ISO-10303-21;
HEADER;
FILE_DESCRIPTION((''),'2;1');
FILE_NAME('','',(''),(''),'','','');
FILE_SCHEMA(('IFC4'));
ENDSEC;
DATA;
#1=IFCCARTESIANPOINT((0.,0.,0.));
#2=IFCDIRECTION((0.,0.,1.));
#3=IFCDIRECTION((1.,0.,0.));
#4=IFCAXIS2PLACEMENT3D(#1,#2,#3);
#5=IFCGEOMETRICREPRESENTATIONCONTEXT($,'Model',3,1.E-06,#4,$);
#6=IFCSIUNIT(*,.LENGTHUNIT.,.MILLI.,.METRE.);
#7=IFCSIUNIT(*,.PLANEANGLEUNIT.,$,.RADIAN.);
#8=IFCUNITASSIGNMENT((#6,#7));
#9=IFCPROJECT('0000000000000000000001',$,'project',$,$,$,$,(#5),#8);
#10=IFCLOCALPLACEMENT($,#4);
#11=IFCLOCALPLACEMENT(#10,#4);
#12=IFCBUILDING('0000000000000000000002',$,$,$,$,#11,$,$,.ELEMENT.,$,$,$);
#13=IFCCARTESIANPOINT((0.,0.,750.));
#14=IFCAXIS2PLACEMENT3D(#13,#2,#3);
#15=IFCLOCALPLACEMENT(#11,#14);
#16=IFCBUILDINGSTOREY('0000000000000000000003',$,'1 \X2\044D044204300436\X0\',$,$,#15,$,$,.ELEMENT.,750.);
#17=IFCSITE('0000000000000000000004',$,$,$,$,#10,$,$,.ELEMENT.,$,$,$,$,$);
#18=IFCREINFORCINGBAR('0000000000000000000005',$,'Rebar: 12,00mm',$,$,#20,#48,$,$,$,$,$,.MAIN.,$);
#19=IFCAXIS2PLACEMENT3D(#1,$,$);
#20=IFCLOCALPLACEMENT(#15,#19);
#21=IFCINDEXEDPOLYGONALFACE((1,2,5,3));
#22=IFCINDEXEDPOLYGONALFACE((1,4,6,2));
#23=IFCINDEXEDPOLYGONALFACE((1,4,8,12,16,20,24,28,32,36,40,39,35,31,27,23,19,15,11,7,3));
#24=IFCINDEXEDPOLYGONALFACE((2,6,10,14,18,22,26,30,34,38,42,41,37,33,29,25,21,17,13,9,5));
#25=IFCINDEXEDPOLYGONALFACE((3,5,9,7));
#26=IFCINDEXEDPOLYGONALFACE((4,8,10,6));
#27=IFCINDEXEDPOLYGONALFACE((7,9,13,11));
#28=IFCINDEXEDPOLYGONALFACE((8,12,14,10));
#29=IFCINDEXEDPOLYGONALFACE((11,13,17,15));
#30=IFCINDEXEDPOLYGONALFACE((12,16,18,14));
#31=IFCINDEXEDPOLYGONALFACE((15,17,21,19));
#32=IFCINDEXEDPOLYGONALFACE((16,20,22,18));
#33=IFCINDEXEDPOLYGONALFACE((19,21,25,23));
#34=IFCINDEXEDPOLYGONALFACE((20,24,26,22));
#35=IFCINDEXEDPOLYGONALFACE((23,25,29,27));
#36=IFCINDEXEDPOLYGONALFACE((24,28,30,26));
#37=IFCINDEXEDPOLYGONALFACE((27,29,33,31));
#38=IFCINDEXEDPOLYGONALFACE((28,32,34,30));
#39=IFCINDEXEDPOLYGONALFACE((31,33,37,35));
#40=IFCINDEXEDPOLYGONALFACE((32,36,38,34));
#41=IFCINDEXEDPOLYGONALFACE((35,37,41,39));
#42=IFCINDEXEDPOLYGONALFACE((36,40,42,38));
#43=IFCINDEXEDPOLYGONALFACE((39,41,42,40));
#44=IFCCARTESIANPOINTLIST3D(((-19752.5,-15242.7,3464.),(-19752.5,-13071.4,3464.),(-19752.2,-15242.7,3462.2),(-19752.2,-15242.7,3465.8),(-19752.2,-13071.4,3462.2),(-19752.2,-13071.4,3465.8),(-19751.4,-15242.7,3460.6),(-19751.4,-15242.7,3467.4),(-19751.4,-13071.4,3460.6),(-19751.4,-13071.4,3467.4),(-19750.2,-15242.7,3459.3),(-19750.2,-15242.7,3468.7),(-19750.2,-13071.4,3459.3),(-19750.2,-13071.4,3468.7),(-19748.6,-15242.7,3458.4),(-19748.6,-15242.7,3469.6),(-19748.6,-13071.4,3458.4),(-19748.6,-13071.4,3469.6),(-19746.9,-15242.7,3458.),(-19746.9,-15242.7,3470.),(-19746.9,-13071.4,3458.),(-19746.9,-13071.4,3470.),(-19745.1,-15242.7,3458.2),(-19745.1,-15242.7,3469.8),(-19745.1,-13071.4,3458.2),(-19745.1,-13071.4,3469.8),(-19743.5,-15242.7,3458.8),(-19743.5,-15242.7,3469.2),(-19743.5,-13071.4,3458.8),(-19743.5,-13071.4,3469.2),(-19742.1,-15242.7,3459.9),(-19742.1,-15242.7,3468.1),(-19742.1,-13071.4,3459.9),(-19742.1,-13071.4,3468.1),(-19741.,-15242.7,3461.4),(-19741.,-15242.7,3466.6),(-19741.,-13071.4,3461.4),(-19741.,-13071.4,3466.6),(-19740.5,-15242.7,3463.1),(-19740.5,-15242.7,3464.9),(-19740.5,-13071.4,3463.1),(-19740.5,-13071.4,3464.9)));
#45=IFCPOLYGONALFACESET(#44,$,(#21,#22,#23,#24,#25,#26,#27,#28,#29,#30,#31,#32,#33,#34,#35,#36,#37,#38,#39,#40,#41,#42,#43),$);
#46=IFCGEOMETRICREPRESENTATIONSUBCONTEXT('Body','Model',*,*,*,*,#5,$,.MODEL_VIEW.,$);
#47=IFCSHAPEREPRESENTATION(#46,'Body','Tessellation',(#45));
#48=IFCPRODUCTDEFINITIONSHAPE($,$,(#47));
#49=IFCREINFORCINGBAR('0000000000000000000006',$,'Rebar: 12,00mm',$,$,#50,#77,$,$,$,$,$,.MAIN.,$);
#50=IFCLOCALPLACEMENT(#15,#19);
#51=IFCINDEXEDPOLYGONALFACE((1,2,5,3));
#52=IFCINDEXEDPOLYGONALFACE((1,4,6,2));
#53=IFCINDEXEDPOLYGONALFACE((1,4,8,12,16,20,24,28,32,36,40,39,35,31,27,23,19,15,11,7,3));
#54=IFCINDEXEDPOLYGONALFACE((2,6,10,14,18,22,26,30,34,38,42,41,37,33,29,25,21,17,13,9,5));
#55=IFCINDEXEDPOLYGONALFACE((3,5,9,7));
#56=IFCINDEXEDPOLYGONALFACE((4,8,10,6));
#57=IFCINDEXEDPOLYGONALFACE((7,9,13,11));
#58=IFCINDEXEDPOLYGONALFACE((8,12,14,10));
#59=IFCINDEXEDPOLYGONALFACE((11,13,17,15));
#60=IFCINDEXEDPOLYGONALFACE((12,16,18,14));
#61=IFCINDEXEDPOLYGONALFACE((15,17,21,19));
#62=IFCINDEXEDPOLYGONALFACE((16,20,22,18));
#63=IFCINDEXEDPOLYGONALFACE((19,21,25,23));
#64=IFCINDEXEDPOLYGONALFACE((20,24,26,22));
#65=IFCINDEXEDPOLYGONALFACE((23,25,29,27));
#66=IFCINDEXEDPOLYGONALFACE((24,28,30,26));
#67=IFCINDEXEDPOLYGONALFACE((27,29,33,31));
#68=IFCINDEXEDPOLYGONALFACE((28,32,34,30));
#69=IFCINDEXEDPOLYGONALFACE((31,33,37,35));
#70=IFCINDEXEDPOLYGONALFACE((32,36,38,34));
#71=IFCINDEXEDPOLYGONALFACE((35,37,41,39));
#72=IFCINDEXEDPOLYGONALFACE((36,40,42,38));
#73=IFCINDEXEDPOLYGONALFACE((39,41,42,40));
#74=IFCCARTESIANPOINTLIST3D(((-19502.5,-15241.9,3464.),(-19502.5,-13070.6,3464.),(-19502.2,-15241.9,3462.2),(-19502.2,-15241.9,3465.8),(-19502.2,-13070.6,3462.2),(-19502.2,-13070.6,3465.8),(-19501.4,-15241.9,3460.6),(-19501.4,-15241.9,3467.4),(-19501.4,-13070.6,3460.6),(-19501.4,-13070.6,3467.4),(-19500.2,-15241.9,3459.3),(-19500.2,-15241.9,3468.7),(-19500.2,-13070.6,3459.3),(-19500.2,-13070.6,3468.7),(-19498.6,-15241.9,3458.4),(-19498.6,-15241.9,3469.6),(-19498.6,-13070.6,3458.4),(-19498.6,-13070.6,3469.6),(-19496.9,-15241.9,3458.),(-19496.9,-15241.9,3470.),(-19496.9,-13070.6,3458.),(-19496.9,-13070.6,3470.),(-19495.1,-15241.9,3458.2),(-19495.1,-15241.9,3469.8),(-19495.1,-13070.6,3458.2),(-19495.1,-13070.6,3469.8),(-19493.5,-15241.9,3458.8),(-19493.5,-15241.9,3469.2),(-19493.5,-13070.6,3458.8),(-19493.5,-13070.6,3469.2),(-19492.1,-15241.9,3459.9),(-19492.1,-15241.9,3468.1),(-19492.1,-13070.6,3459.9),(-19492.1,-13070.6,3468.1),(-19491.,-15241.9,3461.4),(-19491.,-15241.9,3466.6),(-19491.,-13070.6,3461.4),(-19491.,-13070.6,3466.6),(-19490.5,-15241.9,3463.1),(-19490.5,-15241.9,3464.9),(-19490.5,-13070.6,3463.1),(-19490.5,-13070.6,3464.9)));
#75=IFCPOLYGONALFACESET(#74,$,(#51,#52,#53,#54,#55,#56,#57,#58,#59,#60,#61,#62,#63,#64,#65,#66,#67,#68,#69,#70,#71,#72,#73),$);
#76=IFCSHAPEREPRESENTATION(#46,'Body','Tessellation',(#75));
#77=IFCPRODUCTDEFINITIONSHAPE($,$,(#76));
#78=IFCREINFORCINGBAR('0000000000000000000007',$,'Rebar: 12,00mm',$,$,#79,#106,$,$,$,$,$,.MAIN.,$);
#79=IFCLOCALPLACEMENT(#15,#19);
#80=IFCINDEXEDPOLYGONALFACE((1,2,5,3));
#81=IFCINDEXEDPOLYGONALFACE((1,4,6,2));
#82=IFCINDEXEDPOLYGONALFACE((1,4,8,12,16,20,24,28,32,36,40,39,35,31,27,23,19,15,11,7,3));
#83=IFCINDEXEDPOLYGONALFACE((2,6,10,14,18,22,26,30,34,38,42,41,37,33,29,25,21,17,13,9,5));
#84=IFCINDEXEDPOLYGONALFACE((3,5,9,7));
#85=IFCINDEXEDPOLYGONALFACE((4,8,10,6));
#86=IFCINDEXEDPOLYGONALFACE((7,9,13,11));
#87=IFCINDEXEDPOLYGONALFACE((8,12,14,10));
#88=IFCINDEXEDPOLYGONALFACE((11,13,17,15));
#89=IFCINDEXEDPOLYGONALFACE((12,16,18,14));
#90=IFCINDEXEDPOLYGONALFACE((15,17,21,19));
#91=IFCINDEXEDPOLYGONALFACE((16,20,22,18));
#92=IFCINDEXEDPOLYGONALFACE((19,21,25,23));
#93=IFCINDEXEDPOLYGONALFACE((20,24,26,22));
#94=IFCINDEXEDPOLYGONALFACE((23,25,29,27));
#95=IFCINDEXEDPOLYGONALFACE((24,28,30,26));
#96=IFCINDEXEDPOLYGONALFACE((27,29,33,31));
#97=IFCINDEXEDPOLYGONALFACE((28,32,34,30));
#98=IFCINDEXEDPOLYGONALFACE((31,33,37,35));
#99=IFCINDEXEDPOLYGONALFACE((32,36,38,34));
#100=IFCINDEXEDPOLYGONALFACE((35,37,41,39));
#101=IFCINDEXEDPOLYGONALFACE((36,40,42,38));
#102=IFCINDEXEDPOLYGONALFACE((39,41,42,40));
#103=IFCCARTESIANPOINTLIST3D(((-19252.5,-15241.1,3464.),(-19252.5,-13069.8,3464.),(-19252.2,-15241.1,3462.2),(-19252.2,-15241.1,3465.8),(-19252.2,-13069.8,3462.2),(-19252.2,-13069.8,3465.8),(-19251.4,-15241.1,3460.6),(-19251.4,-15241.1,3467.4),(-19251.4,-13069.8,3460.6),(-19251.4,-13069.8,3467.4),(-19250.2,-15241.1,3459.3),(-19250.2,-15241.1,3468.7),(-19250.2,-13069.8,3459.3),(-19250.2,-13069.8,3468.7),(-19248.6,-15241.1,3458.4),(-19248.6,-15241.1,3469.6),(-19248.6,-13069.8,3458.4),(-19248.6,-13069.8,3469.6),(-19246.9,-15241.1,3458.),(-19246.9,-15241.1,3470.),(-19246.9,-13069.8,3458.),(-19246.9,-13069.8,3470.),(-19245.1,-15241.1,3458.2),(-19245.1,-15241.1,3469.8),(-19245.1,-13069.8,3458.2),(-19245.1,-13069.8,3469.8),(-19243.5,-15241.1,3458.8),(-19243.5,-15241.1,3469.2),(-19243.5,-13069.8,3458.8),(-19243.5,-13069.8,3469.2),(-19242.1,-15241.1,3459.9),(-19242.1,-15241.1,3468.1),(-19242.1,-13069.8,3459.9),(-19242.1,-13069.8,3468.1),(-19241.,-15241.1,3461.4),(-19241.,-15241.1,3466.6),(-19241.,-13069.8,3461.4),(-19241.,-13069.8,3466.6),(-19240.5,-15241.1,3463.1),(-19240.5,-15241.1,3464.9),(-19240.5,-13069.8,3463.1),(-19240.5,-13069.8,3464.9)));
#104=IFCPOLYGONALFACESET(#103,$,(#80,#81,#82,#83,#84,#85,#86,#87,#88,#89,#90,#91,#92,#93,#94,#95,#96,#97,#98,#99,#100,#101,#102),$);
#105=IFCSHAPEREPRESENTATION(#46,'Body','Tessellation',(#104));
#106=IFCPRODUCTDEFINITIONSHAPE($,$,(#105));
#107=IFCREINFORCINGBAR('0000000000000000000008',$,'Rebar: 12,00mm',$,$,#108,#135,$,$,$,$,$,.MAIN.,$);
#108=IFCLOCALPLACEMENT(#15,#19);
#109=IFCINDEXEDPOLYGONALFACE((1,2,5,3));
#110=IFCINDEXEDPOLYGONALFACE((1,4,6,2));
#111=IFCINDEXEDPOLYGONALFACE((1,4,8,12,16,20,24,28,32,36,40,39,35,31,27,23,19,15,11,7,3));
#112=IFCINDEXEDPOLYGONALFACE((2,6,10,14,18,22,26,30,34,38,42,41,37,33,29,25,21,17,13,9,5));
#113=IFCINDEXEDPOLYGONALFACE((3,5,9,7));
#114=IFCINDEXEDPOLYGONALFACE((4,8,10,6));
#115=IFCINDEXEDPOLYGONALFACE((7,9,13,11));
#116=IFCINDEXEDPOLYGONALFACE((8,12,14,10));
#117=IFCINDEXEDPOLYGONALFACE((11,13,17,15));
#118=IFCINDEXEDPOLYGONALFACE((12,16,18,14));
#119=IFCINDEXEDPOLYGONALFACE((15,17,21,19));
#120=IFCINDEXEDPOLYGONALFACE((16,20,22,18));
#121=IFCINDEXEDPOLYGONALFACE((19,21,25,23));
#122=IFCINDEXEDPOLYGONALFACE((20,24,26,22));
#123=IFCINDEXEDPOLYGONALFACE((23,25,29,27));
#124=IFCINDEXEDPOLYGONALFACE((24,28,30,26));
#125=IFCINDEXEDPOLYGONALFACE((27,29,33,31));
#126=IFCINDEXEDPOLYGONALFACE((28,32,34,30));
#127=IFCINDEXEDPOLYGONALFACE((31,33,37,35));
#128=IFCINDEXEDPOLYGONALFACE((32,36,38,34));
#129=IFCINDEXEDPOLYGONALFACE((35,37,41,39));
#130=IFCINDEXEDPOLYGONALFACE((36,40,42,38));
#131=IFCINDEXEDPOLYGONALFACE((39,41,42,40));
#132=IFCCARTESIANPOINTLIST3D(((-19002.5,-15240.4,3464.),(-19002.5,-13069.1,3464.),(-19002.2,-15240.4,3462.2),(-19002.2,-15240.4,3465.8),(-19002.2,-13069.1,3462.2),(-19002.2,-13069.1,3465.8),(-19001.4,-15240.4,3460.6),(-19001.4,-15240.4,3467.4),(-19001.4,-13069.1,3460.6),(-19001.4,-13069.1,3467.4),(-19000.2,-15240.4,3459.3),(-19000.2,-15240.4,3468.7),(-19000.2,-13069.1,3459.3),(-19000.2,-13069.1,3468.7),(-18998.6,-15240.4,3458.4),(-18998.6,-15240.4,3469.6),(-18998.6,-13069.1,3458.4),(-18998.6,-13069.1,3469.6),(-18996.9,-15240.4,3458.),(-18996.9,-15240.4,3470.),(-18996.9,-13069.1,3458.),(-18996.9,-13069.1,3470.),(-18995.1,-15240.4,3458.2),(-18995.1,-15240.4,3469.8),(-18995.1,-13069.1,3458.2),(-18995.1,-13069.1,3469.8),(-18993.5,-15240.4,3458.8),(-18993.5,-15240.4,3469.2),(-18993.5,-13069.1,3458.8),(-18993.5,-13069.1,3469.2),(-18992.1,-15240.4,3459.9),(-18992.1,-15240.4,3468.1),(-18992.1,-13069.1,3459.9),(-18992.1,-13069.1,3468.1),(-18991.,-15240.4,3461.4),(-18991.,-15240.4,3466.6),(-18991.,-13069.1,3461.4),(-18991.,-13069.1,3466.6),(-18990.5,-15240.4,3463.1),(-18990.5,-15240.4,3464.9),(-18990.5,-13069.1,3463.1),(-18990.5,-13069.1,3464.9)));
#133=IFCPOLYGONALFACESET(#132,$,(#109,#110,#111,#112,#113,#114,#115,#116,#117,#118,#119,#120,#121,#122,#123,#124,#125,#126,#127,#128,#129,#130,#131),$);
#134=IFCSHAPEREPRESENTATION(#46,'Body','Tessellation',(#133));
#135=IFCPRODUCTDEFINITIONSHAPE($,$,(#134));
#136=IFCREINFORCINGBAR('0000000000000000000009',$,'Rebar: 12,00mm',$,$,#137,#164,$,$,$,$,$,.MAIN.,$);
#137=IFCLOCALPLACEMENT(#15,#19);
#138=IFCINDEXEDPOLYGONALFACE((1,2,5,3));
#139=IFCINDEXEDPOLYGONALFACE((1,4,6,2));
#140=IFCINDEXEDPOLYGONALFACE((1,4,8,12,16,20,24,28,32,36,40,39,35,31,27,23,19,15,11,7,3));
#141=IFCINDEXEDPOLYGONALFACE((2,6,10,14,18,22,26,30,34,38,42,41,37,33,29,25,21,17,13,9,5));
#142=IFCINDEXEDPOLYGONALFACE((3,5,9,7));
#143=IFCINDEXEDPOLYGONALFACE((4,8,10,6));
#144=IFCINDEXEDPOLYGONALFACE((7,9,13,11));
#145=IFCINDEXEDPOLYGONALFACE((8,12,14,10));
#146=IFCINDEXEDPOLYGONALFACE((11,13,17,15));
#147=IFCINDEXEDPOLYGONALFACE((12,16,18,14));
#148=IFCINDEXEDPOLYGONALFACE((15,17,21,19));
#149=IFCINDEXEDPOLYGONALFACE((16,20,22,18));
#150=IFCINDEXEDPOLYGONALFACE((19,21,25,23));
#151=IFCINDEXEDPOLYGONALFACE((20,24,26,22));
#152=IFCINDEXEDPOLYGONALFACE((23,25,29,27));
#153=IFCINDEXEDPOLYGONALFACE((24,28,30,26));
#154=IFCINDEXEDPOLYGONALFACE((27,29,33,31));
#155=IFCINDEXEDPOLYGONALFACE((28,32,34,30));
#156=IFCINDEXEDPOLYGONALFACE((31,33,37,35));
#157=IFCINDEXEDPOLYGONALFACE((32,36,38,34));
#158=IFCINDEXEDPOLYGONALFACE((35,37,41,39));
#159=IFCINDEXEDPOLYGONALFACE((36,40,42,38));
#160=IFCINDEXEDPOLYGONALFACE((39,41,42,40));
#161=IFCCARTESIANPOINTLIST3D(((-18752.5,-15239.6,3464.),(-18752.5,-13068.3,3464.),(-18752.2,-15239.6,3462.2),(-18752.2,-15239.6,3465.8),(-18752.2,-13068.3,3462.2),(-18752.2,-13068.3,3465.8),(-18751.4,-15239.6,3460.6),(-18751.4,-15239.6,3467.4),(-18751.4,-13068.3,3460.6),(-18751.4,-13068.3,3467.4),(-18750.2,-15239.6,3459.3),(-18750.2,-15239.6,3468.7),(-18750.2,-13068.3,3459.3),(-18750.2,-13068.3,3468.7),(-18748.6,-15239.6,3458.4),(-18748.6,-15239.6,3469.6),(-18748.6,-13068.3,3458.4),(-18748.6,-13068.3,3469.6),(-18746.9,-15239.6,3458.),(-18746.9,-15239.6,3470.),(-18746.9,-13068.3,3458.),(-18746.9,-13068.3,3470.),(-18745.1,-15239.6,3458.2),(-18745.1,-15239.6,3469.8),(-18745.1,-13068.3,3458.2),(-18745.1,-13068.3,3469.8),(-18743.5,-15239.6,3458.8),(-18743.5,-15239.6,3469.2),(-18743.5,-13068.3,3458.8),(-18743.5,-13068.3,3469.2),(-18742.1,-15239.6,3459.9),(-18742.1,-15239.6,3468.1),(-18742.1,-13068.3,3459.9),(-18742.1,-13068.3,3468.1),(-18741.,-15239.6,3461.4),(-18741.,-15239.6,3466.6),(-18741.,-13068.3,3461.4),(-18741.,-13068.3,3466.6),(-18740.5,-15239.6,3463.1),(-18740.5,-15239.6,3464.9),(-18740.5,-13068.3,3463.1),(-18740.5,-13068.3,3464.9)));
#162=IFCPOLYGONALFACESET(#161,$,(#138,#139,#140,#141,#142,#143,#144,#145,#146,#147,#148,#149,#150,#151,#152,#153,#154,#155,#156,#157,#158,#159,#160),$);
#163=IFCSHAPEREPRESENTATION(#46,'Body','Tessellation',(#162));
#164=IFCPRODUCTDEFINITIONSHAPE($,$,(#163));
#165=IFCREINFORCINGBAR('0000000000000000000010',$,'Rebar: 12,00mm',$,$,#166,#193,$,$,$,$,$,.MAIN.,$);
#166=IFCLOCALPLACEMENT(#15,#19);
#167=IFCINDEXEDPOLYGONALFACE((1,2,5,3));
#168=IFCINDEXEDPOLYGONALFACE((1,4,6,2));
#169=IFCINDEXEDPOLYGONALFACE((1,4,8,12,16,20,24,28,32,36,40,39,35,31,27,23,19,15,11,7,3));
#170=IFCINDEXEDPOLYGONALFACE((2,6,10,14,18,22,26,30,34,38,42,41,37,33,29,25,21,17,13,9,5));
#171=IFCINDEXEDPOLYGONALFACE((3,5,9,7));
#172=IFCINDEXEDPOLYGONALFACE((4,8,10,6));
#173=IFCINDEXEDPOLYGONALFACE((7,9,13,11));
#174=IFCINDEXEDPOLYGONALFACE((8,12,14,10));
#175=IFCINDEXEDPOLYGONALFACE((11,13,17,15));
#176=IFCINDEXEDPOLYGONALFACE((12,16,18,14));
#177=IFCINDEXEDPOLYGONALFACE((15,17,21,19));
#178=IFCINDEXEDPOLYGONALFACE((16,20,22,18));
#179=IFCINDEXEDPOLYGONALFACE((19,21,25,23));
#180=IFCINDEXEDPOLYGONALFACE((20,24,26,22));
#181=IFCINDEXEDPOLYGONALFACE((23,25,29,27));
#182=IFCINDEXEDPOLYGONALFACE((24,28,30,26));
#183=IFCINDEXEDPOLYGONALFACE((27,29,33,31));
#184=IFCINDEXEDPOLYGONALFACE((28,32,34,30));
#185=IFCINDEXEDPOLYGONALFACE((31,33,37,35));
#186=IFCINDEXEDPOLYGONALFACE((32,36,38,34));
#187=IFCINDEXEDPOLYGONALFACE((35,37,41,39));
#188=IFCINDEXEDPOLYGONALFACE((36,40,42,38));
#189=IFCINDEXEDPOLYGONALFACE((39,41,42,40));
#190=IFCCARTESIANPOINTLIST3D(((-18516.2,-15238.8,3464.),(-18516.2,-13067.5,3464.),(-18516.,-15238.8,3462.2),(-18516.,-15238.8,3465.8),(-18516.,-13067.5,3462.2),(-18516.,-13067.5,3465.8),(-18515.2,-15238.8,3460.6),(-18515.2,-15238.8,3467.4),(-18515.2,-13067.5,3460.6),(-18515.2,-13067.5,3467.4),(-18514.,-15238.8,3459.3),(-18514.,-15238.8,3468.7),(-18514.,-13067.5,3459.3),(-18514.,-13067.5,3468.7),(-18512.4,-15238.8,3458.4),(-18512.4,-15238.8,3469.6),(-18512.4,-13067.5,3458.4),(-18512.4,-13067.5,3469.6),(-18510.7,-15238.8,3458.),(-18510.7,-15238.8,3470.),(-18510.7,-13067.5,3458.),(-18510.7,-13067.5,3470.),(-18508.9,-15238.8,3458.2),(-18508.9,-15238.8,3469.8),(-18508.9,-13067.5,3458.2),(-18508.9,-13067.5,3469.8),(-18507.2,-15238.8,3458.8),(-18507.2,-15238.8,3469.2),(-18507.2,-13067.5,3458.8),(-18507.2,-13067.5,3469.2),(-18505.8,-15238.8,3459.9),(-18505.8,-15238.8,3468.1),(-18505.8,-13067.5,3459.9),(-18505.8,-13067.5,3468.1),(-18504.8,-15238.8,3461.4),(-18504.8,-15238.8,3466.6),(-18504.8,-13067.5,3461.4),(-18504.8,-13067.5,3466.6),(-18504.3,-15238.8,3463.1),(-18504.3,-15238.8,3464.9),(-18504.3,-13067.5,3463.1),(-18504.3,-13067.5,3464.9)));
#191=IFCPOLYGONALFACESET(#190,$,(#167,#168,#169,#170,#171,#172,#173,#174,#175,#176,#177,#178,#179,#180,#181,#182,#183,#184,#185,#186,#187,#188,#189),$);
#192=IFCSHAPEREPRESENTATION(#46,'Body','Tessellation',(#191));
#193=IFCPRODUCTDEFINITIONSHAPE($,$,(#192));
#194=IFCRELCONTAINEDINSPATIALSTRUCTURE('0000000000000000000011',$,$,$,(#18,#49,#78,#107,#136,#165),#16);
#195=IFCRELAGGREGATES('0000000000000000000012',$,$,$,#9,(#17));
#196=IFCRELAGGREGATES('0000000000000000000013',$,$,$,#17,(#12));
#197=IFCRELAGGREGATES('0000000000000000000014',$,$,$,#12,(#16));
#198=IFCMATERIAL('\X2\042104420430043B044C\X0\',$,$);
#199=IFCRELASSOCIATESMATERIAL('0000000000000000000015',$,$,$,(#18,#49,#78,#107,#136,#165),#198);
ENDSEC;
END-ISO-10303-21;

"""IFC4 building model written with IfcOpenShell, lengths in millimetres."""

from ifc_helpers import new_model, entity, si_unit, frame, origin_with_axes, place, context, subcontext, project, spatial, source, transform, mapped, material, element, save


model = new_model("IFC4")

# Units and contexts
model_context = context("Model", 3, precision=1e-06, world=origin_with_axes())
body_context = subcontext(model_context, "Body", "Model", "MODEL_VIEW")
ifc_project = project(units=[si_unit("LENGTHUNIT", "METRE", prefix="MILLI"), si_unit("PLANEANGLEUNIT", "RADIAN")], contexts=[model_context])

# Site, building, storey
site_placement = place(None, origin_with_axes())
site = spatial("IfcSite", under=ifc_project, at=site_placement, CompositionType="ELEMENT")
building_placement = place(site_placement, origin_with_axes())
building = spatial("IfcBuilding", under=site, at=building_placement, CompositionType="ELEMENT")
storey_placement = place(building_placement, frame((0.0, 0.0, 750.0), z_axis=(0.0, 0.0, 1.0), x_axis=(1.0, 0.0, 0.0)))
storey = spatial("IfcBuildingStorey", under=building, at=storey_placement, Name="1 этаж", CompositionType="ELEMENT", Elevation=750.0)

# Reinforcing bars
ifc_material = material(Name="Сталь")
shared_shape_1 = source(origin_with_axes(), body_context, "Body", "AdvancedSweptSolid", [
    entity("IfcSweptDiskSolid", entity("IfcIndexedPolyCurve", entity("IfcCartesianPointList3D", [[0.0, 0.0, 0.0], [2171.3, 0.0, 0.0]]), [entity("IfcLineIndex", [1, 2])]), 6.0),
])
reinforcing_bar_1_placement = place(storey_placement, origin_with_axes())
element("IfcReinforcingBar", 1, at=reinforcing_bar_1_placement, inside=storey, material=ifc_material, Name="Rebar: 12,00mm", PredefinedType="MAIN", context=body_context, shape_type="MappedRepresentation", body=[
    mapped(shared_shape_1, transform((-19746.5, -15242.7, 3464.0), x_axis=(0.0, 1.0, 0.0), y_axis=(-1.0, 0.0, 0.0), z_axis=(0.0, 0.0, 1.0), scale=1.0)),
])
reinforcing_bar_2_placement = place(storey_placement, origin_with_axes())
element("IfcReinforcingBar", 2, at=reinforcing_bar_2_placement, inside=storey, material=ifc_material, Name="Rebar: 12,00mm", PredefinedType="MAIN", context=body_context, shape_type="MappedRepresentation", body=[
    mapped(shared_shape_1, transform((-19496.5, -15241.9, 3464.0), x_axis=(0.0, 1.0, 0.0), y_axis=(-1.0, 0.0, 0.0), z_axis=(0.0, 0.0, 1.0), scale=1.0)),
])
reinforcing_bar_3_placement = place(storey_placement, origin_with_axes())
element("IfcReinforcingBar", 3, at=reinforcing_bar_3_placement, inside=storey, material=ifc_material, Name="Rebar: 12,00mm", PredefinedType="MAIN", context=body_context, shape_type="MappedRepresentation", body=[
    mapped(shared_shape_1, transform((-19246.5, -15241.1, 3464.0), x_axis=(0.0, 1.0, 0.0), y_axis=(-1.0, 0.0, 0.0), z_axis=(0.0, 0.0, 1.0), scale=1.0)),
])
reinforcing_bar_4_placement = place(storey_placement, origin_with_axes())
element("IfcReinforcingBar", 4, at=reinforcing_bar_4_placement, inside=storey, material=ifc_material, Name="Rebar: 12,00mm", PredefinedType="MAIN", context=body_context, shape_type="MappedRepresentation", body=[
    mapped(shared_shape_1, transform((-18996.5, -15240.4, 3464.0), x_axis=(0.0, 1.0, 0.0), y_axis=(-1.0, 0.0, 0.0), z_axis=(0.0, 0.0, 1.0), scale=1.0)),
])
reinforcing_bar_5_placement = place(storey_placement, origin_with_axes())
element("IfcReinforcingBar", 5, at=reinforcing_bar_5_placement, inside=storey, material=ifc_material, Name="Rebar: 12,00mm", PredefinedType="MAIN", context=body_context, shape_type="MappedRepresentation", body=[
    mapped(shared_shape_1, transform((-18746.5, -15239.6, 3464.0), x_axis=(0.0, 1.0, 0.0), y_axis=(-1.0, 0.0, 0.0), z_axis=(0.0, 0.0, 1.0), scale=1.0)),
])
reinforcing_bar_6_placement = place(storey_placement, origin_with_axes())
element("IfcReinforcingBar", 6, at=reinforcing_bar_6_placement, inside=storey, material=ifc_material, Name="Rebar: 12,00mm", PredefinedType="MAIN", context=body_context, shape_type="MappedRepresentation", body=[
    mapped(shared_shape_1, transform((-18510.2, -15238.8, 3464.0), x_axis=(0.0, 1.0, 0.0), y_axis=(-1.0, 0.0, 0.0), z_axis=(0.0, 0.0, 1.0), scale=1.0)),
])

save(model, "model.ifc")
